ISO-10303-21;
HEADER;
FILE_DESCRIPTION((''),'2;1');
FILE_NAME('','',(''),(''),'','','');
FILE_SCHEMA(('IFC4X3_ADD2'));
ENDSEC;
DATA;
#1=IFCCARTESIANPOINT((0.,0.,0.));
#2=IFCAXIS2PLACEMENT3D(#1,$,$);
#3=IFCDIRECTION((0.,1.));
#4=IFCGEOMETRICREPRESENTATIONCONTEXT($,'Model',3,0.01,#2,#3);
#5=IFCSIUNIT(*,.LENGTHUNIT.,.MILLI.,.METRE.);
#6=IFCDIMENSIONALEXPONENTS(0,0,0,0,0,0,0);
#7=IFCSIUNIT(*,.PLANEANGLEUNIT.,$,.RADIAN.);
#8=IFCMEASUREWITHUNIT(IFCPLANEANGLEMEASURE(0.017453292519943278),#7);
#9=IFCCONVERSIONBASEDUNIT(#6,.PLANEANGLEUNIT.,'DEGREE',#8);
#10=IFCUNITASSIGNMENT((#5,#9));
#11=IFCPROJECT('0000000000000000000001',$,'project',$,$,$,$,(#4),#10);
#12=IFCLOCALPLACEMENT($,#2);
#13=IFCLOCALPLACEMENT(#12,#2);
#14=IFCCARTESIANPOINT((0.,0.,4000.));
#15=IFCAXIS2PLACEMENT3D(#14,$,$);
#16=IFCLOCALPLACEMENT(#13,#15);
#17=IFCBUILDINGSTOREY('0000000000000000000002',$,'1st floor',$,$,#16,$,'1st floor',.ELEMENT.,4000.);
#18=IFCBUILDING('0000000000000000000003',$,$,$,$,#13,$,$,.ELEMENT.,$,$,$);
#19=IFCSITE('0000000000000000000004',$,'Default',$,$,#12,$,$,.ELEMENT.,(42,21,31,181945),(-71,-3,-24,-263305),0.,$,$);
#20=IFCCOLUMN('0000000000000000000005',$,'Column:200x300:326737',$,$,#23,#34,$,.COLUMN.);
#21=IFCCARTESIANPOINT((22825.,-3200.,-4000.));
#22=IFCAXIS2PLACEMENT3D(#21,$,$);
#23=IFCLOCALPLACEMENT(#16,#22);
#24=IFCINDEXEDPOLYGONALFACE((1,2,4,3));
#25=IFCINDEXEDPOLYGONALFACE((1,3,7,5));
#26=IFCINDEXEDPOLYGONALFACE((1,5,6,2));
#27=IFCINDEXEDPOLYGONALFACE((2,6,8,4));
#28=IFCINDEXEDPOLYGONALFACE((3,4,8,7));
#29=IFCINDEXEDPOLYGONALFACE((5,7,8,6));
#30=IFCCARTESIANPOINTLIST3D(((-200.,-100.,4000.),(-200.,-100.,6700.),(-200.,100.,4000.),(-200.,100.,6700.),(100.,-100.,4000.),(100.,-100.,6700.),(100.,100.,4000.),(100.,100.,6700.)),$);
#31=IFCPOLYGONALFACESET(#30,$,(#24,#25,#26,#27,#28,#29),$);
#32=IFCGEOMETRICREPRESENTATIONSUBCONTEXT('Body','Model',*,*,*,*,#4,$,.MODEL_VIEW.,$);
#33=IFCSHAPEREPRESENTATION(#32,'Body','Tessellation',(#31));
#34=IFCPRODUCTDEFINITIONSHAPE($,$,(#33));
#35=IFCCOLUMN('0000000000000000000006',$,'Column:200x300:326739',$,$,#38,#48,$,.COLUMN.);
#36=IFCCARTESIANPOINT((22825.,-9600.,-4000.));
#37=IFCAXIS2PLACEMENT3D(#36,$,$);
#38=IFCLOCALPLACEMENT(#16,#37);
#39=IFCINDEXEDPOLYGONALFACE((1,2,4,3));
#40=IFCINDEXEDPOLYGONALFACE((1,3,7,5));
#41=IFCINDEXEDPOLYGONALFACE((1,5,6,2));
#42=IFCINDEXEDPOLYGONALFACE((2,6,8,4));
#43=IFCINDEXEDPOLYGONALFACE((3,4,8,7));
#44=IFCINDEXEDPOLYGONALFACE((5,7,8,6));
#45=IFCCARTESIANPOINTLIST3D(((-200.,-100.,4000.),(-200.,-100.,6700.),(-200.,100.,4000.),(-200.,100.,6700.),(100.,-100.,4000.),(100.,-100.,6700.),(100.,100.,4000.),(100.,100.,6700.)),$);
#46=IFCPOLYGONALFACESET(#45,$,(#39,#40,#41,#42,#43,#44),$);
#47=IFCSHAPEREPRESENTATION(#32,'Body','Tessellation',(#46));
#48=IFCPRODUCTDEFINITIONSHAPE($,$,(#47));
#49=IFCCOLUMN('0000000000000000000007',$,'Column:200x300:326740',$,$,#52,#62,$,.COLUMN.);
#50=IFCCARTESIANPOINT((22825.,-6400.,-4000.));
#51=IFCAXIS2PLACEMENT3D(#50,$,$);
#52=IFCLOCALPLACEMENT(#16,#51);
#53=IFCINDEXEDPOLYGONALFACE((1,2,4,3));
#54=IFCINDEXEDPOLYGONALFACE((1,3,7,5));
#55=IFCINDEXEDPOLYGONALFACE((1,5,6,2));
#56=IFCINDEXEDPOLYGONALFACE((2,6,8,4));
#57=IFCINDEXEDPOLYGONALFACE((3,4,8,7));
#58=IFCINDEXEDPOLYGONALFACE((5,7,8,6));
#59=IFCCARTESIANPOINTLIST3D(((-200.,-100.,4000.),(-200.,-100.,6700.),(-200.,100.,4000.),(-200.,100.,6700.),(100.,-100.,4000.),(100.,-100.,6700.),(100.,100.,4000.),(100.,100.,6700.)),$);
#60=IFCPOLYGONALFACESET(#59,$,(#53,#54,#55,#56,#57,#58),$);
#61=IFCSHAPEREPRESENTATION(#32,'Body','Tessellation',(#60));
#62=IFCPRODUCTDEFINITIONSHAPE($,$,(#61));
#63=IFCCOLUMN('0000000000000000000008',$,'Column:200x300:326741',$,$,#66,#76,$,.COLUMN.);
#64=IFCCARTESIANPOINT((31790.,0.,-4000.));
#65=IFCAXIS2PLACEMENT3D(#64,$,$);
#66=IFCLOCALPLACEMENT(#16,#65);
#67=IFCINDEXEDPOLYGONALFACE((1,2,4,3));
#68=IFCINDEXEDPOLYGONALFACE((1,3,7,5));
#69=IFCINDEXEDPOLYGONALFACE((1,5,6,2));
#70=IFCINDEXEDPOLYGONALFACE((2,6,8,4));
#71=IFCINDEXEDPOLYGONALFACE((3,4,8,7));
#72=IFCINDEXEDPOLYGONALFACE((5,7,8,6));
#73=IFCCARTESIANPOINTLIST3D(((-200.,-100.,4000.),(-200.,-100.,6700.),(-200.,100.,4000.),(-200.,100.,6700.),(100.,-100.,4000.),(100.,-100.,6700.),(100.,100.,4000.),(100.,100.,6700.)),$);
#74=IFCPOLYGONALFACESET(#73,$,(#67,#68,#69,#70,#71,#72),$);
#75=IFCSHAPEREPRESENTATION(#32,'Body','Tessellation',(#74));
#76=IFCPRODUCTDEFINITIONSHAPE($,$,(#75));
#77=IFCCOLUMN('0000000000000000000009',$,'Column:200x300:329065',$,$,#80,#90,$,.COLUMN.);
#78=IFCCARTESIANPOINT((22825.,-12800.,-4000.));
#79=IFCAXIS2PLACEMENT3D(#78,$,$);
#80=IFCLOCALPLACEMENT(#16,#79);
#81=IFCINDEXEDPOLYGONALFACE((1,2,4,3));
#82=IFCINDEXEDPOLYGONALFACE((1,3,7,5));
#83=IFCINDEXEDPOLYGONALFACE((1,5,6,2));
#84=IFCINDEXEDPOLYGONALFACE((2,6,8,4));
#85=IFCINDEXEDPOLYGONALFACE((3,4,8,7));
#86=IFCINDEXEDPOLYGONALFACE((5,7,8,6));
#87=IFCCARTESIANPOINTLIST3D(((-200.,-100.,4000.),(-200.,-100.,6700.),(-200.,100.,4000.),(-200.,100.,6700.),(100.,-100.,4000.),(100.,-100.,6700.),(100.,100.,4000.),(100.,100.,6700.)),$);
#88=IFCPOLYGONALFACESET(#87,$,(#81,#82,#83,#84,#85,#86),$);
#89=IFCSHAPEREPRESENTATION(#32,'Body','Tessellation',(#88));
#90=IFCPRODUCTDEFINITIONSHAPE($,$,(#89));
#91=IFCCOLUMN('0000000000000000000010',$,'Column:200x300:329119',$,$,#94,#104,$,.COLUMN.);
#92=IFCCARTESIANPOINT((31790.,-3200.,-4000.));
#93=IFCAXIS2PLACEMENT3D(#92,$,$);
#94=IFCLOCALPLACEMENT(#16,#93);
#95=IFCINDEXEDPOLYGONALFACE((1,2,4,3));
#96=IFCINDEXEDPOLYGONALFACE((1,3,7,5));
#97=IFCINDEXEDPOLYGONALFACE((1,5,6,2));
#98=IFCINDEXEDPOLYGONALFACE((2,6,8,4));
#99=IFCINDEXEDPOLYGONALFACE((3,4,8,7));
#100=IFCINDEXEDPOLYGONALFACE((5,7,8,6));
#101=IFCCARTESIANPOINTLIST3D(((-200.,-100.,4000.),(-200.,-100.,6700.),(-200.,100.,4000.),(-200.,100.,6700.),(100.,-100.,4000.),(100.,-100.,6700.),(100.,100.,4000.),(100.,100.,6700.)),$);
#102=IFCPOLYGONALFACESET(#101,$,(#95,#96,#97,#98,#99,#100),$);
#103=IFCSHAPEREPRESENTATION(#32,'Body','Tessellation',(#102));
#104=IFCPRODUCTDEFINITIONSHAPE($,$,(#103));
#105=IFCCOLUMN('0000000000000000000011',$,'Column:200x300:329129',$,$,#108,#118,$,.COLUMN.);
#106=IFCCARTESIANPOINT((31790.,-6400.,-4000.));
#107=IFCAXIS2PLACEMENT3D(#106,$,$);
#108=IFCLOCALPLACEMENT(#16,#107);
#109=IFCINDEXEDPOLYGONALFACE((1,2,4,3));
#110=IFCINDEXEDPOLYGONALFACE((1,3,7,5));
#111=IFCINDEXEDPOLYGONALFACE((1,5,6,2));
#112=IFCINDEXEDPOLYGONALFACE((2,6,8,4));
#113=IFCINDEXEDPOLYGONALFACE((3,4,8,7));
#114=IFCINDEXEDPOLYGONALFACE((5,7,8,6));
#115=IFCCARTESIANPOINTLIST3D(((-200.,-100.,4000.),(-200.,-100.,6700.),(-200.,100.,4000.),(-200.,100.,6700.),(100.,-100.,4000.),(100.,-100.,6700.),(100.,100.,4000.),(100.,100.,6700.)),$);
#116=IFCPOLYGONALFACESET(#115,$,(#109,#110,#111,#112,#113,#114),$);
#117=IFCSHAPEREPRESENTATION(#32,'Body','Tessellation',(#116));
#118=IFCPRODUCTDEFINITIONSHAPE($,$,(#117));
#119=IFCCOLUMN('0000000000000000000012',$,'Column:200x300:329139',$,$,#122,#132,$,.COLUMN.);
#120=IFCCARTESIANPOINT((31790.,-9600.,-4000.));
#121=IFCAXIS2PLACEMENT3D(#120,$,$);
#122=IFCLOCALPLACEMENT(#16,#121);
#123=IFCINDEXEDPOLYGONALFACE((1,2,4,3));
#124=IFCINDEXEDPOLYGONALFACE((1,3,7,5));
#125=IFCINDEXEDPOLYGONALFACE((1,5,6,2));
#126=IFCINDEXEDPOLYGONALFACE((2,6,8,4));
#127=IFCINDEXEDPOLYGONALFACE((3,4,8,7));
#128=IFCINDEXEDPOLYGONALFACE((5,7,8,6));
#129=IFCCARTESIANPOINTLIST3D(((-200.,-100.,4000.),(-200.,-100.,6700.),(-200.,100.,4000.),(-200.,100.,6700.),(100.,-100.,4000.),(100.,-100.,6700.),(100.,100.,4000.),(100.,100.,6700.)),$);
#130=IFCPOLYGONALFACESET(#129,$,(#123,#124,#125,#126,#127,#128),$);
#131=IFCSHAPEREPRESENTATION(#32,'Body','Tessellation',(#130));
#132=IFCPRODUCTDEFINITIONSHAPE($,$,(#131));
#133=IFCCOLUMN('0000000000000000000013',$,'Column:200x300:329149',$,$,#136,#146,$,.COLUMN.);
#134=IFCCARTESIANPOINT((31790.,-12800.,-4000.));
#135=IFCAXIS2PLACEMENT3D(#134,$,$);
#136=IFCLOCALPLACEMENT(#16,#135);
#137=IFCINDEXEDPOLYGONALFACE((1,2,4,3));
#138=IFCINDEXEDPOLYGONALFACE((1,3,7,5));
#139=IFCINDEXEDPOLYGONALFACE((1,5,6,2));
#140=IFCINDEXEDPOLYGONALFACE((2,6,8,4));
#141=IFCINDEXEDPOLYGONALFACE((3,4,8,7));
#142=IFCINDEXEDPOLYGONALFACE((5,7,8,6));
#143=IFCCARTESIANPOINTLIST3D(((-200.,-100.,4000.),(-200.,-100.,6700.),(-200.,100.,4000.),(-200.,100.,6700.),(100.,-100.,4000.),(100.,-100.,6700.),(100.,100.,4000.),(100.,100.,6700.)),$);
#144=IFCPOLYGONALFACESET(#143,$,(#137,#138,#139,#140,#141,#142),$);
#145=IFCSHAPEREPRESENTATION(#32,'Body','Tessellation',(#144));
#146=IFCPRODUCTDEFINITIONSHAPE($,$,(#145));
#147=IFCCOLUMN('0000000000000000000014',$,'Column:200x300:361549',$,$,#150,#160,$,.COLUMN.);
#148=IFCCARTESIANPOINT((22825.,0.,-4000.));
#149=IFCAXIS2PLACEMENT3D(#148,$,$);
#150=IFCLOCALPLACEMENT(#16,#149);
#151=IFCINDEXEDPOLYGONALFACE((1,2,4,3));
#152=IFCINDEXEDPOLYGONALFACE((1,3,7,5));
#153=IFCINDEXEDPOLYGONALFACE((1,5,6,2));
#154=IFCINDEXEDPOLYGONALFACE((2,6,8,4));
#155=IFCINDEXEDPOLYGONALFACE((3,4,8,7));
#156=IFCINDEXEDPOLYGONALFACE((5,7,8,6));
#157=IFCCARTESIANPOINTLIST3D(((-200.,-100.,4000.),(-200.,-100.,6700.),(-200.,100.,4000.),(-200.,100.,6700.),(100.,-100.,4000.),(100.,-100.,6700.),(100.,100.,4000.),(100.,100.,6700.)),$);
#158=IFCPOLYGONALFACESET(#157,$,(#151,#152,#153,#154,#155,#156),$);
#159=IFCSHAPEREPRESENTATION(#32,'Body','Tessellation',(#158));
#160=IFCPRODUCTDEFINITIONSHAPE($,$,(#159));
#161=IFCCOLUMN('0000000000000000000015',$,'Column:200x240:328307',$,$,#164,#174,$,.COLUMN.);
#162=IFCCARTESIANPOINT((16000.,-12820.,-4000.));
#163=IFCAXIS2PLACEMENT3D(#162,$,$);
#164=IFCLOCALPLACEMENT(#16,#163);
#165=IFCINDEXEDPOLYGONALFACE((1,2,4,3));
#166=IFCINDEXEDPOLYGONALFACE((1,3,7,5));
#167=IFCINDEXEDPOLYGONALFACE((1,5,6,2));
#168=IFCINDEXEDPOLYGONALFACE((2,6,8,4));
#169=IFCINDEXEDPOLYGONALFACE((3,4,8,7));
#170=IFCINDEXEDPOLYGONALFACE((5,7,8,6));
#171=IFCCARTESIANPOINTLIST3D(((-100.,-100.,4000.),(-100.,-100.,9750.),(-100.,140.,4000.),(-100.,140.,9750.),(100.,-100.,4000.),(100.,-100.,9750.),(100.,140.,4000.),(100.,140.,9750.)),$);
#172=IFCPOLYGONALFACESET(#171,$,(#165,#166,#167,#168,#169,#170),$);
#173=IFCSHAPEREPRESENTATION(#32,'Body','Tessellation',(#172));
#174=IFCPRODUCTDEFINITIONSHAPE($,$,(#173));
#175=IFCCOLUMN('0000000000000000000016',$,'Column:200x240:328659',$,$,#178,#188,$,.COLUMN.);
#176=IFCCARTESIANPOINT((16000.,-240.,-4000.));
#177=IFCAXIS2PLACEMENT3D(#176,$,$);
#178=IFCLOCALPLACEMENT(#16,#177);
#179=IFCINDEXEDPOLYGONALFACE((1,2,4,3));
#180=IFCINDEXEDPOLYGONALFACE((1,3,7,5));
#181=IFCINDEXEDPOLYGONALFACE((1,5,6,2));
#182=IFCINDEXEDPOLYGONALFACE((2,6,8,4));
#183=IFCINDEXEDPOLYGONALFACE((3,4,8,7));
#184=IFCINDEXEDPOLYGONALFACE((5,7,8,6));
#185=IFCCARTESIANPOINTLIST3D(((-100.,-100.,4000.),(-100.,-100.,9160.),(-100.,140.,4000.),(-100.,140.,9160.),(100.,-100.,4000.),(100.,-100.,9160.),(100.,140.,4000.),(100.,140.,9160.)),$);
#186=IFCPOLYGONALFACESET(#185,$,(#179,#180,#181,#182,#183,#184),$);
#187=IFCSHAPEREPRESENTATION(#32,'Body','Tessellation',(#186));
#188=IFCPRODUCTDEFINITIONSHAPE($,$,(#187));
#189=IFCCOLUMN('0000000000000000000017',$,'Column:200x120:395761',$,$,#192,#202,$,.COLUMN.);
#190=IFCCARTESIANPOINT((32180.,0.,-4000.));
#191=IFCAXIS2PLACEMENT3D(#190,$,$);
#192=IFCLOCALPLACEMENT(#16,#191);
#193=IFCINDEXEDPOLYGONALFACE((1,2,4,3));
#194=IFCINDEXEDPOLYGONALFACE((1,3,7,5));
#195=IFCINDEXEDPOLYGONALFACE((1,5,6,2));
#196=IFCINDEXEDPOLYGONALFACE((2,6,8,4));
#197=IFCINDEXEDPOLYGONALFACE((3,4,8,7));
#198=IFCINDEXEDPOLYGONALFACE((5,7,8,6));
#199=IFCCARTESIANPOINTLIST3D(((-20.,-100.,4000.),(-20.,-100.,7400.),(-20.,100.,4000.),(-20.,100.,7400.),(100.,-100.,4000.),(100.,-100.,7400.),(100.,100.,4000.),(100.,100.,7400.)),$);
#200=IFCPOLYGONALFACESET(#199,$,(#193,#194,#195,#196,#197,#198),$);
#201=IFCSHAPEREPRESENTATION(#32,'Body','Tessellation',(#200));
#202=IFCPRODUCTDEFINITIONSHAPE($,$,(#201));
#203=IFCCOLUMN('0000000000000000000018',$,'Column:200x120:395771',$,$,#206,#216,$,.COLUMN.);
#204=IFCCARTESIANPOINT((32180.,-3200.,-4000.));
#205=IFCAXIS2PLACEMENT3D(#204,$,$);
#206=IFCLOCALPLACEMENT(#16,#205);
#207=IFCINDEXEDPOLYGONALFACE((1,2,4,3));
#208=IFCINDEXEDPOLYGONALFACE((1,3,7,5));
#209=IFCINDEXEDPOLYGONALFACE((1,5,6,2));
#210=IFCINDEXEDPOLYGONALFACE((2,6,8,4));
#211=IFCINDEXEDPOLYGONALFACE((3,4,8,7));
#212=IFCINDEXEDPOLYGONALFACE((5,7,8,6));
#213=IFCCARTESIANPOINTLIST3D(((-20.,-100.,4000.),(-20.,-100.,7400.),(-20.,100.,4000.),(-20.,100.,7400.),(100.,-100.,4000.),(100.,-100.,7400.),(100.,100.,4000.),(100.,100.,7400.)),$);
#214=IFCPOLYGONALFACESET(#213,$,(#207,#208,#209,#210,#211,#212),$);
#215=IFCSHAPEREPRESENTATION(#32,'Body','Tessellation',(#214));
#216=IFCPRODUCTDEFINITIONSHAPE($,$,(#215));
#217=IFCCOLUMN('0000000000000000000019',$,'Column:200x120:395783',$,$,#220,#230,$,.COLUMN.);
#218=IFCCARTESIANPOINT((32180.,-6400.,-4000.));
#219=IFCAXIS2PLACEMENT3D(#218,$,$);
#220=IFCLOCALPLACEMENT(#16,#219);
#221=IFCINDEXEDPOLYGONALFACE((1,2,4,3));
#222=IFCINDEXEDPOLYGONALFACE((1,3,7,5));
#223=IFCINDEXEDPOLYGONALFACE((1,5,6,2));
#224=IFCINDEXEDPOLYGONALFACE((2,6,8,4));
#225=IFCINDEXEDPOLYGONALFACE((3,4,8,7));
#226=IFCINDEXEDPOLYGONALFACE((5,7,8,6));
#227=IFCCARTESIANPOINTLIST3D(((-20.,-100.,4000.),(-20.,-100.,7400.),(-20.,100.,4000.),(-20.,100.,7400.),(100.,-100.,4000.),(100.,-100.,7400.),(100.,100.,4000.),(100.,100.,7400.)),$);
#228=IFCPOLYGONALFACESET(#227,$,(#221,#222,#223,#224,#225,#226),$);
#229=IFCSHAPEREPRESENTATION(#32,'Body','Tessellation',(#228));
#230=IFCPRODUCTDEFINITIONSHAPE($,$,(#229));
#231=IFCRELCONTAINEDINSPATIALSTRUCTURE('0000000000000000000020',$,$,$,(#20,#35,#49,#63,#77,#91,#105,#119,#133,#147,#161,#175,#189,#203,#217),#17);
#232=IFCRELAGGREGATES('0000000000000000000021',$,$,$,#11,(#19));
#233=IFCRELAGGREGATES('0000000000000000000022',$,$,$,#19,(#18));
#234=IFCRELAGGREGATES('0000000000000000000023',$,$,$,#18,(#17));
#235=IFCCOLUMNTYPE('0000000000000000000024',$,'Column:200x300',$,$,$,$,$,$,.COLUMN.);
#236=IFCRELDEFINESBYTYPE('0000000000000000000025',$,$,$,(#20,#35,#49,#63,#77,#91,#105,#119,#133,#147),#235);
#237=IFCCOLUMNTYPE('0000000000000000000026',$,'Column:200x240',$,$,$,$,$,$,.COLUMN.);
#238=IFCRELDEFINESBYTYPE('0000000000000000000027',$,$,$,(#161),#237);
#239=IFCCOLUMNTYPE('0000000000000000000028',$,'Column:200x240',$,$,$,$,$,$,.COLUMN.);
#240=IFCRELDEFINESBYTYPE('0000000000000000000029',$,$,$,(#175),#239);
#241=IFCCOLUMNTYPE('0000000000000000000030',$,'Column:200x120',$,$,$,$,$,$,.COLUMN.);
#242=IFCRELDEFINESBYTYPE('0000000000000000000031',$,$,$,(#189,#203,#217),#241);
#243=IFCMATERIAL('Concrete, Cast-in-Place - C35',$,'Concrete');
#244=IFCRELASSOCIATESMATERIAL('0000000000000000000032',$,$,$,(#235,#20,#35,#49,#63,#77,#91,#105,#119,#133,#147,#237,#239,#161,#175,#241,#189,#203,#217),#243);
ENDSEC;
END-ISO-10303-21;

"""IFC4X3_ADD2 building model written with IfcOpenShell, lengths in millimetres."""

from ifc_helpers import new_model, entity, si_unit, converted_unit, direction, frame, origin, origin_2d_with_axis, place, context, subcontext, project, spatial, rectangle, extrude, source, transform, mapped, material, material_profile, profile_set, profile_usage, type_object, type_shapes, element, save


model = new_model("IFC4X3_ADD2")

# Units and contexts
model_context = context("Model", 3, precision=0.01, world=origin(), true_north=direction((0.0, 1.0)))
body_context = subcontext(model_context, "Body", "Model", "MODEL_VIEW")
ifc_project = project(units=[si_unit("LENGTHUNIT", "METRE", prefix="MILLI"), converted_unit("PLANEANGLEUNIT", "DEGREE", entity("IfcPlaneAngleMeasure", 0.017453292519943278), si_unit("PLANEANGLEUNIT", "RADIAN"), dimensions=[0, 0, 0, 0, 0, 0, 0])], contexts=[model_context])

# Site, building, storey
site_placement = place(None, origin())
site = spatial("IfcSite", under=ifc_project, at=site_placement, Name="Default", CompositionType="ELEMENT", RefLatitude=(42, 21, 31, 181945), RefLongitude=(-71, -3, -24, -263305), RefElevation=0.0)
building_placement = place(site_placement, origin())
building = spatial("IfcBuilding", under=site, at=building_placement, CompositionType="ELEMENT")
storey_placement = place(building_placement, frame((0.0, 0.0, 4000.0)))
storey = spatial("IfcBuildingStorey", under=building, at=storey_placement, Name="1st floor", LongName="1st floor", CompositionType="ELEMENT", Elevation=4000.0)

# Columns
ifc_material_1 = material(Name="Concrete, Cast-in-Place - C35", Category="Concrete")
ifc_material_profile_1 = material_profile(ifc_material_1, rectangle(XDim=300.0, YDim=200.0, at=origin_2d_with_axis()), Name="200x300")
ifc_profile_set_1 = profile_set([ifc_material_profile_1], Name="200x300")
ifc_profile_usage_1 = profile_usage(ifc_profile_set_1)
column_type_1 = type_object("IfcColumnType", Name="Column:200x300", PredefinedType="COLUMN", material=ifc_profile_set_1)
shared_shape_1 = source(origin(), body_context, "Body", "SweptSolid", [
    extrude(rectangle(XDim=300.0, YDim=200.0, at=origin_2d_with_axis()), frame((-50.0, 0.0, 4000.0), z_axis=(0.0, 0.0, 1.0), x_axis=(-1.0, 0.0, 0.0)), (0.0, 0.0, 1.0), 2700.0),
])
type_shapes(column_type_1, [shared_shape_1])
for number, where, name in (
    (1, (22825.0, -3200.0, -4000.0), "Column:200x300:326737"),
    (2, (22825.0, -9600.0, -4000.0), "Column:200x300:326739"),
    (3, (22825.0, -6400.0, -4000.0), "Column:200x300:326740"),
    (4, (31790.0, 0.0, -4000.0), "Column:200x300:326741"),
    (5, (22825.0, -12800.0, -4000.0), "Column:200x300:329065"),
    (6, (31790.0, -3200.0, -4000.0), "Column:200x300:329119"),
    (7, (31790.0, -6400.0, -4000.0), "Column:200x300:329129"),
    (8, (31790.0, -9600.0, -4000.0), "Column:200x300:329139"),
    (9, (31790.0, -12800.0, -4000.0), "Column:200x300:329149"),
    (10, (22825.0, 0.0, -4000.0), "Column:200x300:361549"),
):
    element("IfcColumn", number, at=place(storey_placement, frame(where)), inside=storey, type_object=column_type_1, material=ifc_profile_usage_1, Name=name, PredefinedType="COLUMN", context=body_context, shape_type="MappedRepresentation", body=[
        mapped(shared_shape_1, transform((0.0, 0.0, 0.0), scale=1.0)),
    ])
ifc_material_profile_2 = material_profile(ifc_material_1, rectangle(XDim=200.0, YDim=240.0, at=origin_2d_with_axis()), Name="200x240")
ifc_profile_set_2 = profile_set([ifc_material_profile_2], Name="200x240")
ifc_profile_usage_2 = profile_usage(ifc_profile_set_2)
column_type_2 = type_object("IfcColumnType", Name="Column:200x240", PredefinedType="COLUMN", material=ifc_profile_set_2)
shared_shape_2 = source(origin(), body_context, "Body", "SweptSolid", [
    extrude(rectangle(XDim=200.0, YDim=240.0, at=origin_2d_with_axis()), frame((0.0, 20.0, 4000.0), z_axis=(0.0, 0.0, 1.0), x_axis=(-1.0, 0.0, 0.0)), (0.0, 0.0, 1.0), 5750.0),
])
type_shapes(column_type_2, [shared_shape_2])
column_1_placement = place(storey_placement, frame((16000.0, -12820.0, -4000.0)))
element("IfcColumn", 11, at=column_1_placement, inside=storey, type_object=column_type_2, material=ifc_profile_usage_2, Name="Column:200x240:328307", PredefinedType="COLUMN", context=body_context, shape_type="MappedRepresentation", body=[
    mapped(shared_shape_2, transform((0.0, 0.0, 0.0), scale=1.0)),
])
column_type_3 = type_object("IfcColumnType", Name="Column:200x240", PredefinedType="COLUMN", material=ifc_profile_set_2)
shared_shape_3 = source(origin(), body_context, "Body", "SweptSolid", [
    extrude(rectangle(XDim=200.0, YDim=240.0, at=origin_2d_with_axis()), frame((0.0, 20.0, 4000.0), z_axis=(0.0, 0.0, 1.0), x_axis=(-1.0, 0.0, 0.0)), (0.0, 0.0, 1.0), 5160.0),
])
type_shapes(column_type_3, [shared_shape_3])
column_2_placement = place(storey_placement, frame((16000.0, -240.0, -4000.0)))
element("IfcColumn", 12, at=column_2_placement, inside=storey, type_object=column_type_3, material=ifc_profile_usage_2, Name="Column:200x240:328659", PredefinedType="COLUMN", context=body_context, shape_type="MappedRepresentation", body=[
    mapped(shared_shape_3, transform((0.0, 0.0, 0.0), scale=1.0)),
])
ifc_material_profile_3 = material_profile(ifc_material_1, rectangle(XDim=120.0, YDim=200.0, at=origin_2d_with_axis()), Name="200x120")
ifc_profile_set_3 = profile_set([ifc_material_profile_3], Name="200x120")
ifc_profile_usage_3 = profile_usage(ifc_profile_set_3)
column_type_4 = type_object("IfcColumnType", Name="Column:200x120", PredefinedType="COLUMN", material=ifc_profile_set_3)
shared_shape_4 = source(origin(), body_context, "Body", "SweptSolid", [
    extrude(rectangle(XDim=120.0, YDim=200.0, at=origin_2d_with_axis()), frame((40.0, 0.0, 4000.0), z_axis=(0.0, 0.0, 1.0), x_axis=(-1.0, 0.0, 0.0)), (0.0, 0.0, 1.0), 3400.0),
])
type_shapes(column_type_4, [shared_shape_4])
for number, where, name in (
    (13, (32180.0, 0.0, -4000.0), "Column:200x120:395761"),
    (14, (32180.0, -3200.0, -4000.0), "Column:200x120:395771"),
    (15, (32180.0, -6400.0, -4000.0), "Column:200x120:395783"),
):
    element("IfcColumn", number, at=place(storey_placement, frame(where)), inside=storey, type_object=column_type_4, material=ifc_profile_usage_3, Name=name, PredefinedType="COLUMN", context=body_context, shape_type="MappedRepresentation", body=[
        mapped(shared_shape_4, transform((0.0, 0.0, 0.0), scale=1.0)),
    ])

save(model, "model.ifc")
